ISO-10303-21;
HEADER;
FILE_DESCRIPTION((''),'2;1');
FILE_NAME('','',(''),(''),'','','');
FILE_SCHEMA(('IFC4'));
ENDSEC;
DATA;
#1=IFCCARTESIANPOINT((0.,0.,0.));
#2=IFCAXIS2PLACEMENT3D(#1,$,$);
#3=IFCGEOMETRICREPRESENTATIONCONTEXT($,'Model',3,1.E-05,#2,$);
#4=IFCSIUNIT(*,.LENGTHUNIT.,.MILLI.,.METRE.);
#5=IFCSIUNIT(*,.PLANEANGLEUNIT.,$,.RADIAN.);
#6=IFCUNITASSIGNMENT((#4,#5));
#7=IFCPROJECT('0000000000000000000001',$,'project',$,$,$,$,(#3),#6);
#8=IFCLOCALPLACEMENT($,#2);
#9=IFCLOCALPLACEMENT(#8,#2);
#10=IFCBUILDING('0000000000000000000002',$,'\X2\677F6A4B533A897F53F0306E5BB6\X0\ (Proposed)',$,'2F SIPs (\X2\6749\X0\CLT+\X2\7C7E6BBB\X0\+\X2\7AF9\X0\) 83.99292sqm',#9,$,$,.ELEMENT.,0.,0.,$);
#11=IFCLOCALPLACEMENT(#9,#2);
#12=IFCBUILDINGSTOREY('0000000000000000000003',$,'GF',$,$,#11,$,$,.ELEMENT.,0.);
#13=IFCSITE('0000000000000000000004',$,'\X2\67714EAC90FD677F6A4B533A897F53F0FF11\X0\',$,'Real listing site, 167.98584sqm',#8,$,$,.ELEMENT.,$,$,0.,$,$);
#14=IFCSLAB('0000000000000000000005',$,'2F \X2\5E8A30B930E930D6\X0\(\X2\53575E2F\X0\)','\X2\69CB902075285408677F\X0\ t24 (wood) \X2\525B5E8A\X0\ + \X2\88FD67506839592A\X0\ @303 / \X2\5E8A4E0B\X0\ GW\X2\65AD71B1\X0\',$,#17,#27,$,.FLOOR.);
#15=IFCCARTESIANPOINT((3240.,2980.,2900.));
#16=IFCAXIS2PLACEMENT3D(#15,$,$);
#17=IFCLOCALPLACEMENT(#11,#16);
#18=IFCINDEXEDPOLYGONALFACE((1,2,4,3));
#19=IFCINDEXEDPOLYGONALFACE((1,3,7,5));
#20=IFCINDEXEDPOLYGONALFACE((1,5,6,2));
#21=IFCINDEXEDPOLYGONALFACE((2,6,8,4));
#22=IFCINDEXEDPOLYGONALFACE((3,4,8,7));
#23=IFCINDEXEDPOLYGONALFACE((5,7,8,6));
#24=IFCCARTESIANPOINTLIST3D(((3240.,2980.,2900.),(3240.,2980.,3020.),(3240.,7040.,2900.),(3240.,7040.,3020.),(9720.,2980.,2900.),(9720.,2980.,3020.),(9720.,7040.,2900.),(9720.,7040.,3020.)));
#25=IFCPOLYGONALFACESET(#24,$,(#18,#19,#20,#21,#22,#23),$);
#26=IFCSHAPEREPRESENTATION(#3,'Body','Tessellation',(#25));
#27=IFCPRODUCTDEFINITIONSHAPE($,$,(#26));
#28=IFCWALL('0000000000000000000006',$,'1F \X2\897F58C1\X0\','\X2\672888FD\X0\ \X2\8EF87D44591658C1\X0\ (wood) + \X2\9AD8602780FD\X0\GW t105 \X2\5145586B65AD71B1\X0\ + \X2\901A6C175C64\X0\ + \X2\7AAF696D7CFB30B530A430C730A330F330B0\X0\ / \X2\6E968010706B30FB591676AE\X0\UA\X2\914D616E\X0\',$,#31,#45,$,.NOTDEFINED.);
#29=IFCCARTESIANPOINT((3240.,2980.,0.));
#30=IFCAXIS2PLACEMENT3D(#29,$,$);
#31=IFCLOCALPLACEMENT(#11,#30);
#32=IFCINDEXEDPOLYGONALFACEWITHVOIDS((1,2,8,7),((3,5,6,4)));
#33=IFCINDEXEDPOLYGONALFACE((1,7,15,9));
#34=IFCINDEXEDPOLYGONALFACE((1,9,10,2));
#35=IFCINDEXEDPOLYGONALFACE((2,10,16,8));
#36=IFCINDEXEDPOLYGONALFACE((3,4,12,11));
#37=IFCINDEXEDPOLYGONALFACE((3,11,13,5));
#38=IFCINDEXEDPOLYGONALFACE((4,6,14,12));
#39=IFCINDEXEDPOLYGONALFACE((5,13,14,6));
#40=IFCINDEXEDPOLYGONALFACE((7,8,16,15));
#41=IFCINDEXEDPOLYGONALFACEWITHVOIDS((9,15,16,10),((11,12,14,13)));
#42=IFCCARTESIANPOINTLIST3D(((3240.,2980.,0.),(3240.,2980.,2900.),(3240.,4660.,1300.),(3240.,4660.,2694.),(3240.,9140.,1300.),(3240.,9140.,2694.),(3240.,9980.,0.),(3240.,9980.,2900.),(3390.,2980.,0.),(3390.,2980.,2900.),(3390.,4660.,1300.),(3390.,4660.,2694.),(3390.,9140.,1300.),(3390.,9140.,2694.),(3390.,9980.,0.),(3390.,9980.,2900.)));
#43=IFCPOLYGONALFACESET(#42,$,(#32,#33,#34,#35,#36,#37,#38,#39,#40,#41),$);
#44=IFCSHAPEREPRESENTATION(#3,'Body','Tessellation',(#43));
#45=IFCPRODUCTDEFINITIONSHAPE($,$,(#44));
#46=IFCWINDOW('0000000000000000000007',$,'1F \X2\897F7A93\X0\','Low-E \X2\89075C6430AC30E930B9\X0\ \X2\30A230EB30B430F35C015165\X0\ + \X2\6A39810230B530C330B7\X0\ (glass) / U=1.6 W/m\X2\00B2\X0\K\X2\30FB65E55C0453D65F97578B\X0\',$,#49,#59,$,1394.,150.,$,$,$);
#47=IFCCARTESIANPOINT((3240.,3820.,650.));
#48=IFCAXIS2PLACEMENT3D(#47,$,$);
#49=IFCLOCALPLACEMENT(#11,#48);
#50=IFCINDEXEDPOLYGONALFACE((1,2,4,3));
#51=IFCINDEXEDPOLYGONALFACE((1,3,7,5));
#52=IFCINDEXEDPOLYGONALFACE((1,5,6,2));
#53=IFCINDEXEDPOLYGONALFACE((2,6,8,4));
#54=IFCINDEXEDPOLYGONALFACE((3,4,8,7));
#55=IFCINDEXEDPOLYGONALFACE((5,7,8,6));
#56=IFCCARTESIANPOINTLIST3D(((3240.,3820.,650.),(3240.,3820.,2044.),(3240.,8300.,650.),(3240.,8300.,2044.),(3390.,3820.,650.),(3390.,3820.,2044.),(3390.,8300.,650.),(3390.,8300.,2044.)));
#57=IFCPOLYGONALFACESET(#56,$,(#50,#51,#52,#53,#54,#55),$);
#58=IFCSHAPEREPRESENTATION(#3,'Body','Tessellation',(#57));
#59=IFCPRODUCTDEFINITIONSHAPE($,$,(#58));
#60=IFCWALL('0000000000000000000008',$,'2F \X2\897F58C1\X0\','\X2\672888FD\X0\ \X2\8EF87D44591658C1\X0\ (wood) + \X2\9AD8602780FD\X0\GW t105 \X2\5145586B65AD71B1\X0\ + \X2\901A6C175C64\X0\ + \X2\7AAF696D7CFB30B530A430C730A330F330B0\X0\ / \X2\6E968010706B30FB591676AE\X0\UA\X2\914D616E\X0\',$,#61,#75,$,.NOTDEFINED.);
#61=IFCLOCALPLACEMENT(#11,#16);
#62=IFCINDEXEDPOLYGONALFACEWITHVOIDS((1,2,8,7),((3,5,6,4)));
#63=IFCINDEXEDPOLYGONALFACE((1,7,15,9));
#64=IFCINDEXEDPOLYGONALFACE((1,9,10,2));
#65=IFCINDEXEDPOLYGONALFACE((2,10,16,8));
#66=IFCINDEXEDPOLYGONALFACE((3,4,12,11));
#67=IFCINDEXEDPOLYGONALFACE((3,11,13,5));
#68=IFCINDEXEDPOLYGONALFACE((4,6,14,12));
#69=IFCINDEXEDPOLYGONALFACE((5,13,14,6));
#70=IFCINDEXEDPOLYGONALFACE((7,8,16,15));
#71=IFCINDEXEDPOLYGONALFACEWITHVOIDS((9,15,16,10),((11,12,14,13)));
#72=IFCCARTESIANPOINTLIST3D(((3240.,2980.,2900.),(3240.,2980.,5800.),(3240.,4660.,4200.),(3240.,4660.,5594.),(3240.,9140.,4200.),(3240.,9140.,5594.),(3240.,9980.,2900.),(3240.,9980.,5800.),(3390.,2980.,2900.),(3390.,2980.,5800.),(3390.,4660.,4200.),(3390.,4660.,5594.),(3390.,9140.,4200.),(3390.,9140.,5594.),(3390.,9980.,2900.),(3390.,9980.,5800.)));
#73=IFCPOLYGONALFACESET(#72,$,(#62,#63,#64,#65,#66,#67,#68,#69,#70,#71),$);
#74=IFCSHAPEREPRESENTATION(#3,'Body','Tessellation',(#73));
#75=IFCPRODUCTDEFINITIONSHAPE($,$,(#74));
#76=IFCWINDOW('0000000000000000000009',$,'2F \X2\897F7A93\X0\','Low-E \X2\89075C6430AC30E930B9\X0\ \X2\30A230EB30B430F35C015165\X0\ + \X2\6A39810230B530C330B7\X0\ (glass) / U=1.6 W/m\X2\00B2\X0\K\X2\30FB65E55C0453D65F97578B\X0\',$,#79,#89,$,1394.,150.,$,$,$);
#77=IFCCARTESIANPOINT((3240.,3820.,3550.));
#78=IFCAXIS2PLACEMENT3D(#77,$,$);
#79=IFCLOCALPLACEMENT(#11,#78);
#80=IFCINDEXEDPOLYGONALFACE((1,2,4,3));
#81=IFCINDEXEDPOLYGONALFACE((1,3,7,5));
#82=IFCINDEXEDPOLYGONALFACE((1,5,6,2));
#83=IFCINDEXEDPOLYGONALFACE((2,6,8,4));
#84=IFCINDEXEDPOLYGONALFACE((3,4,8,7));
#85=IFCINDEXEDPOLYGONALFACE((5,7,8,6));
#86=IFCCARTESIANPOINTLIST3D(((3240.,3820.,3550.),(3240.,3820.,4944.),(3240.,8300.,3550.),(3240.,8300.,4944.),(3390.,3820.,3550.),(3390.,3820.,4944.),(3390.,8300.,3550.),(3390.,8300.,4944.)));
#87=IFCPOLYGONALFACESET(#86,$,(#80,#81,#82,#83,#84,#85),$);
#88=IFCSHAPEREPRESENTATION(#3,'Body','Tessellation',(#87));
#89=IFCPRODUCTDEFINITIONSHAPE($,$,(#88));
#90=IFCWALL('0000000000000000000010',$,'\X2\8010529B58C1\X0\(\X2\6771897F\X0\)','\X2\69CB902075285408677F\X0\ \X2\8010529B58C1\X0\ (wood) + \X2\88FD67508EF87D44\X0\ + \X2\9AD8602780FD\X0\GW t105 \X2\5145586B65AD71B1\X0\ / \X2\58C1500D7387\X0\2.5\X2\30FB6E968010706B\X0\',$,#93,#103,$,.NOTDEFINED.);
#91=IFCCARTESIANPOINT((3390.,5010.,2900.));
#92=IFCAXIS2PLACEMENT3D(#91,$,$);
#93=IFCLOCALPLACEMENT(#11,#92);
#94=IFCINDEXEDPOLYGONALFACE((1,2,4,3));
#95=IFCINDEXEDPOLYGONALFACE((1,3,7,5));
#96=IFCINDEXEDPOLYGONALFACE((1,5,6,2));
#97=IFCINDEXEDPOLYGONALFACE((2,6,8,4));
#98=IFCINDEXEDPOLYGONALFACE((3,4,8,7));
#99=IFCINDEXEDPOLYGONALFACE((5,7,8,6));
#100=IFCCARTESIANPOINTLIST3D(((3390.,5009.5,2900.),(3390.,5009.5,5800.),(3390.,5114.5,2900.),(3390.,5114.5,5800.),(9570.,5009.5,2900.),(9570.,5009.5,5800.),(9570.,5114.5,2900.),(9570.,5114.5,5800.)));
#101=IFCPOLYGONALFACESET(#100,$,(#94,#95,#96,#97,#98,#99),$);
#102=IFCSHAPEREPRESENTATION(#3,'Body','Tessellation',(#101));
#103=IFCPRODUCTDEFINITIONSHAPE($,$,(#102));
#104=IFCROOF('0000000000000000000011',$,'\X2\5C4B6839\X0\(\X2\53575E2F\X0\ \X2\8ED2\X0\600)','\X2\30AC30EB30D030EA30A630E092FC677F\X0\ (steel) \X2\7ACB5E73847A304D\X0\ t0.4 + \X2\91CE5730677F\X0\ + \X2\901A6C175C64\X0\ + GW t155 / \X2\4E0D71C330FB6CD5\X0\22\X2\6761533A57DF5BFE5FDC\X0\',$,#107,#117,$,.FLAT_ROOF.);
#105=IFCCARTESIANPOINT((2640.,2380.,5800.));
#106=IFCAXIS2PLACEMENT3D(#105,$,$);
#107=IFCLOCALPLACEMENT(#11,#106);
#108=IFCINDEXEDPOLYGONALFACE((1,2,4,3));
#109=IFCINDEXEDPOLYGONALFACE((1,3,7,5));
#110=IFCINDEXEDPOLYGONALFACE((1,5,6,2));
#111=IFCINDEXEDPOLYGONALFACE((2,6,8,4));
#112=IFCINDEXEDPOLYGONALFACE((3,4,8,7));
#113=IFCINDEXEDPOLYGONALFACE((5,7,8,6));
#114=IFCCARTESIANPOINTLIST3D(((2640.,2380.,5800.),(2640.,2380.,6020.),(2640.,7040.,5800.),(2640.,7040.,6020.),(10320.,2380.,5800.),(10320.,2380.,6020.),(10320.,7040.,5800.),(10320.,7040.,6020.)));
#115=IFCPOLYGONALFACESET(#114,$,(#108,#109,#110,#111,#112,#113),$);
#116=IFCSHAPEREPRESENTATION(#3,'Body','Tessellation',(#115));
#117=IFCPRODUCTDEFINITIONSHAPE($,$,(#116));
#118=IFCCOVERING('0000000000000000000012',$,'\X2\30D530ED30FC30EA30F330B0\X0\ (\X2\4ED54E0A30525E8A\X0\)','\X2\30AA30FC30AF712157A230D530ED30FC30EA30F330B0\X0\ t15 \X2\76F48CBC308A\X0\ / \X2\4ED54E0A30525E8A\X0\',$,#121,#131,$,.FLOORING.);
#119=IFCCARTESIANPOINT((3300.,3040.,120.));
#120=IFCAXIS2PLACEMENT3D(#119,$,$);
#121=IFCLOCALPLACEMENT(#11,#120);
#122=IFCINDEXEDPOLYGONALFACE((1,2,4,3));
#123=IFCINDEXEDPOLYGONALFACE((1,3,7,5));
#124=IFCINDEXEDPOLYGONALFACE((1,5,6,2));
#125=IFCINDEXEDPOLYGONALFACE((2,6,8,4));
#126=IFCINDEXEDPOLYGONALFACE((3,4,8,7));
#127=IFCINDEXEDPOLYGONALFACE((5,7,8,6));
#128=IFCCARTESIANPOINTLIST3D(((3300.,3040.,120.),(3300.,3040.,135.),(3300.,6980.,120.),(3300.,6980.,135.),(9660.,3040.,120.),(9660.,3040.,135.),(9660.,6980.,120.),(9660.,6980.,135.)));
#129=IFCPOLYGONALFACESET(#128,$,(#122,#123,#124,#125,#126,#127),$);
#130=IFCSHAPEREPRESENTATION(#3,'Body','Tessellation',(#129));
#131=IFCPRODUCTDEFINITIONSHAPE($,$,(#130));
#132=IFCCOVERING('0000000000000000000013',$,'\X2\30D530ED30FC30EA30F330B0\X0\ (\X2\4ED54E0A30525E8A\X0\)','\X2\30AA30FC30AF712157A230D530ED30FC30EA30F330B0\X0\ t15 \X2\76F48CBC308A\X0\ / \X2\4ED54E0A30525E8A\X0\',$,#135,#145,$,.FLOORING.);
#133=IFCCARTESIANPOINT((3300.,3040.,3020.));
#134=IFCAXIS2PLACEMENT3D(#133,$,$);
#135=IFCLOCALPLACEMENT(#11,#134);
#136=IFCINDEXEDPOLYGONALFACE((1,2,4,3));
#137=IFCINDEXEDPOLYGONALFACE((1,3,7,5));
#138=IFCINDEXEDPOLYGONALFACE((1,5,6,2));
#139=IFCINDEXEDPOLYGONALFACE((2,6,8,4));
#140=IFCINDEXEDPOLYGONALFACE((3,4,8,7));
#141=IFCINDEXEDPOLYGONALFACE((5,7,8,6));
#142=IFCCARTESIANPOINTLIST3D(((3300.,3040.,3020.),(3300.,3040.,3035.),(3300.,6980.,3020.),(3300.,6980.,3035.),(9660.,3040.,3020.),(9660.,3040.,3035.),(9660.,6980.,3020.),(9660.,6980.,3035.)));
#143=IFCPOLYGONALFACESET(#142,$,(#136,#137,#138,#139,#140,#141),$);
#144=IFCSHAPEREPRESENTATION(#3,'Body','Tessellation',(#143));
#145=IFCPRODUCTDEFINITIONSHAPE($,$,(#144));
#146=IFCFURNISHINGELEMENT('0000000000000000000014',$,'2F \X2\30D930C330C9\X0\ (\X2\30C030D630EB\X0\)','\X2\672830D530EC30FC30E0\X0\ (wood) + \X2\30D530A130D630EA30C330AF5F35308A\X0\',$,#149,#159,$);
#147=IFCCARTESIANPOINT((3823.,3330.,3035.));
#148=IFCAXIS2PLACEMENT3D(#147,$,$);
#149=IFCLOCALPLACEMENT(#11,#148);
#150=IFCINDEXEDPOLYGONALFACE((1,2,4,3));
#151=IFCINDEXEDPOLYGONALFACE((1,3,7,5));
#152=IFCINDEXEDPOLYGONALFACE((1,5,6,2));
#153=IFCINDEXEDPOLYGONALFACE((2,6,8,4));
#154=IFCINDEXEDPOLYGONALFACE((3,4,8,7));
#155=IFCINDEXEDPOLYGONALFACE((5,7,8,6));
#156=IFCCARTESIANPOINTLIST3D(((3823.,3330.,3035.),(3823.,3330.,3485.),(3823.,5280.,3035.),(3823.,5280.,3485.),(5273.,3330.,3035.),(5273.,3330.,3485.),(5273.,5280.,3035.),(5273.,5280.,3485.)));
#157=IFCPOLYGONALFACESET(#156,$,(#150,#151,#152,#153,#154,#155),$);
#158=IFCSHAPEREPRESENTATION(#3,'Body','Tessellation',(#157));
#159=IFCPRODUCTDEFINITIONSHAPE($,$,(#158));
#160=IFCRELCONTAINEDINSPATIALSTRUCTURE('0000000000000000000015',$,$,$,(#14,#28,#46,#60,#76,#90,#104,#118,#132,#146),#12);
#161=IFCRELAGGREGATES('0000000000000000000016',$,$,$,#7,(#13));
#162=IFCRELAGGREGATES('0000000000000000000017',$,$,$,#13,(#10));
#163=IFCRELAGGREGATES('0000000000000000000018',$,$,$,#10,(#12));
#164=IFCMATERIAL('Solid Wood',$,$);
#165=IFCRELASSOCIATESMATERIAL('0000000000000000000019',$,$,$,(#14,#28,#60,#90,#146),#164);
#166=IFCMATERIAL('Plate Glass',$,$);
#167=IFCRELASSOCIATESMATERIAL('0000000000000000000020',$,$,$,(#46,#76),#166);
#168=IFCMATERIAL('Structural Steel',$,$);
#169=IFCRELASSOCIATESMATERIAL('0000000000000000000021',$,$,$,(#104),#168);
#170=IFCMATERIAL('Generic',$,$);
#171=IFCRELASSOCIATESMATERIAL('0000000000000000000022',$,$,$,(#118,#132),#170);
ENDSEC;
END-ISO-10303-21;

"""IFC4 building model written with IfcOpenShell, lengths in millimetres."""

from ifc_helpers import new_model, si_unit, frame, frame_2d, origin, place, context, project, spatial, rectangle, extrude, material, element, fill, save


model = new_model("IFC4")

# Units and contexts
model_context = context("Model", 3, precision=1e-05, world=origin())
ifc_project = project(units=[si_unit("LENGTHUNIT", "METRE", prefix="MILLI"), si_unit("PLANEANGLEUNIT", "RADIAN")], contexts=[model_context])

# Site, building, storey
site_placement = place(None, origin())
site = spatial("IfcSite", under=ifc_project, at=site_placement, Name="東京都板橋区西台１", ObjectType="Real listing site, 167.98584sqm", CompositionType="ELEMENT", RefElevation=0.0)
building_placement = place(site_placement, origin())
building = spatial("IfcBuilding", under=site, at=building_placement, Name="板橋区西台の家 (Proposed)", ObjectType="2F SIPs (杉CLT+籾殻+竹) 83.99292sqm", CompositionType="ELEMENT", ElevationOfRefHeight=0.0, ElevationOfTerrain=0.0)
storey_placement = place(building_placement, origin())
storey = spatial("IfcBuildingStorey", under=building, at=storey_placement, Name="GF", CompositionType="ELEMENT", Elevation=0.0)

# Slab
ifc_material_1 = material(Name="Solid Wood")
slab_1_placement = place(storey_placement, frame((3240.0, 2980.0, 2900.0)))
element("IfcSlab", 1, at=slab_1_placement, inside=storey, material=ifc_material_1, Name="2F 床スラブ(南帯)", Description="構造用合板 t24 (wood) 剛床 + 製材根太 @303 / 床下 GW断熱", PredefinedType="FLOOR", context=model_context, shape_type="SweptSolid", body=[
    extrude(rectangle(XDim=6480.0, YDim=4060.0, at=frame_2d((3240.0, 2030.0))), frame((3240.0, 2980.0, 2900.0)), (0.0, 0.0, 1.0), 120.0),
])

# Shared definitions
ifc_material_2 = material(Name="Plate Glass")

# Wall, opening, window
wall_1_placement = place(storey_placement, frame((3240.0, 2980.0, 0.0)))
wall_1 = element("IfcWall", 2, at=wall_1_placement, inside=storey, material=ifc_material_1, Name="1F 西壁", Description="木製 軸組外壁 (wood) + 高性能GW t105 充填断熱 + 通気層 + 窯業系サイディング / 準耐火・外皮UA配慮", PredefinedType="NOTDEFINED", context=model_context, shape_type="SweptSolid", body=[
    extrude(rectangle(XDim=150.0, YDim=7000.0, at=frame_2d((75.0, 3500.0))), frame((3240.0, 2980.0, 0.0)), (0.0, 0.0, 1.0), 2900.0),
])
opening_1_placement = place(storey_placement, frame((3240.0, 3820.0, 650.0)))
opening_1 = element("IfcOpeningElement", 3, at=opening_1_placement, cuts=wall_1, PredefinedType="NOTDEFINED", context=model_context, shape_type="SweptSolid", body=[
    extrude(rectangle(XDim=150.0, YDim=4480.0, at=frame_2d((75.0, 2240.0))), frame((3240.0, 3820.0, 650.0)), (0.0, 0.0, 1.0), 1394.0),
])
window_1_placement = place(storey_placement, frame((3240.0, 3820.0, 650.0)))
window_1 = element("IfcWindow", 4, at=window_1_placement, inside=storey, material=ifc_material_2, Name="1F 西窓", Description="Low-E 複層ガラス アルゴン封入 + 樹脂サッシ (glass) / U=1.6 W/m²K・日射取得型", OverallHeight=1394.0, OverallWidth=150.0, context=model_context, shape_type="SweptSolid", body=[
    extrude(rectangle(XDim=150.0, YDim=4480.0, at=frame_2d((75.0, 2240.0))), frame((3240.0, 3820.0, 650.0)), (0.0, 0.0, 1.0), 1394.0),
])
fill(opening_1, window_1)

# Wall, opening, window
wall_2_placement = place(storey_placement, frame((3240.0, 2980.0, 2900.0)))
wall_2 = element("IfcWall", 5, at=wall_2_placement, inside=storey, material=ifc_material_1, Name="2F 西壁", Description="木製 軸組外壁 (wood) + 高性能GW t105 充填断熱 + 通気層 + 窯業系サイディング / 準耐火・外皮UA配慮", PredefinedType="NOTDEFINED", context=model_context, shape_type="SweptSolid", body=[
    extrude(rectangle(XDim=150.0, YDim=7000.0, at=frame_2d((75.0, 3500.0))), frame((3240.0, 2980.0, 2900.0)), (0.0, 0.0, 1.0), 2900.0),
])
opening_2_placement = place(storey_placement, frame((3240.0, 3820.0, 3550.0)))
opening_2 = element("IfcOpeningElement", 6, at=opening_2_placement, cuts=wall_2, PredefinedType="NOTDEFINED", context=model_context, shape_type="SweptSolid", body=[
    extrude(rectangle(XDim=150.0, YDim=4480.0, at=frame_2d((75.0, 2240.0))), frame((3240.0, 3820.0, 3550.0)), (0.0, 0.0, 1.0), 1394.0),
])
window_2_placement = place(storey_placement, frame((3240.0, 3820.0, 3550.0)))
window_2 = element("IfcWindow", 7, at=window_2_placement, inside=storey, material=ifc_material_2, Name="2F 西窓", Description="Low-E 複層ガラス アルゴン封入 + 樹脂サッシ (glass) / U=1.6 W/m²K・日射取得型", OverallHeight=1394.0, OverallWidth=150.0, context=model_context, shape_type="SweptSolid", body=[
    extrude(rectangle(XDim=150.0, YDim=4480.0, at=frame_2d((75.0, 2240.0))), frame((3240.0, 3820.0, 3550.0)), (0.0, 0.0, 1.0), 1394.0),
])
fill(opening_2, window_2)

# Wall
wall_3_placement = place(storey_placement, frame((3390.0, 5010.0, 2900.0)))
element("IfcWall", 8, at=wall_3_placement, inside=storey, material=ifc_material_1, Name="耐力壁(東西)", Description="構造用合板 耐力壁 (wood) + 製材軸組 + 高性能GW t105 充填断熱 / 壁倍率2.5・準耐火", PredefinedType="NOTDEFINED", context=model_context, shape_type="SweptSolid", body=[
    extrude(rectangle(XDim=6180.0, YDim=105.0, at=frame_2d((3090.0, 52.0))), frame((3390.0, 5010.0, 2900.0)), (0.0, 0.0, 1.0), 2900.0),
])

# Roof
ifc_material_3 = material(Name="Structural Steel")
for number, where, name in (
    (9, (2640.0, 2380.0, 5800.0), "屋根(南帯 軒600)"),
):
    element("IfcRoof", number, at=place(storey_placement, frame(where)), inside=storey, material=ifc_material_3, Name=name, Description="ガルバリウム鋼板 (steel) 立平葺き t0.4 + 野地板 + 通気層 + GW t155 / 不燃・法22条区域対応", PredefinedType="FLAT_ROOF", context=model_context, shape_type="SweptSolid", body=[
        extrude(rectangle(XDim=7680.0, YDim=4660.0, at=frame_2d((3840.0, 2330.0))), frame((2640.0, 2380.0, 5800.0)), (0.0, 0.0, 1.0), 220.0),
    ])

# Coverings
ifc_material_4 = material(Name="Generic")
covering_1_placement = place(storey_placement, frame((3300.0, 3040.0, 120.0)))
element("IfcCovering", 10, at=covering_1_placement, inside=storey, material=ifc_material_4, Name="フローリング (仕上げ床)", Description="オーク無垢フローリング t15 直貼り / 仕上げ床", PredefinedType="FLOORING", context=model_context, shape_type="SweptSolid", body=[
    extrude(rectangle(XDim=6360.0, YDim=3940.0, at=frame_2d((3180.0, 1970.0))), frame((3300.0, 3040.0, 120.0)), (0.0, 0.0, 1.0), 15.0),
])
covering_2_placement = place(storey_placement, frame((3300.0, 3040.0, 3020.0)))
element("IfcCovering", 11, at=covering_2_placement, inside=storey, material=ifc_material_4, Name="フローリング (仕上げ床)", Description="オーク無垢フローリング t15 直貼り / 仕上げ床", PredefinedType="FLOORING", context=model_context, shape_type="SweptSolid", body=[
    extrude(rectangle(XDim=6360.0, YDim=3940.0, at=frame_2d((3180.0, 1970.0))), frame((3300.0, 3040.0, 3020.0)), (0.0, 0.0, 1.0), 15.0),
])

# Furnishing element
furnishing_placement = place(storey_placement, frame((3823.0, 3330.0, 3035.0)))
element("IfcFurnishingElement", 12, at=furnishing_placement, inside=storey, material=ifc_material_1, Name="2F ベッド (ダブル)", Description="木フレーム (wood) + ファブリック張り", context=model_context, shape_type="SweptSolid", body=[
    extrude(rectangle(XDim=1450.0, YDim=1950.0, at=frame_2d((725.0, 975.0))), frame((3823.0, 3330.0, 3035.0)), (0.0, 0.0, 1.0), 450.0),
])

save(model, "model.ifc")
